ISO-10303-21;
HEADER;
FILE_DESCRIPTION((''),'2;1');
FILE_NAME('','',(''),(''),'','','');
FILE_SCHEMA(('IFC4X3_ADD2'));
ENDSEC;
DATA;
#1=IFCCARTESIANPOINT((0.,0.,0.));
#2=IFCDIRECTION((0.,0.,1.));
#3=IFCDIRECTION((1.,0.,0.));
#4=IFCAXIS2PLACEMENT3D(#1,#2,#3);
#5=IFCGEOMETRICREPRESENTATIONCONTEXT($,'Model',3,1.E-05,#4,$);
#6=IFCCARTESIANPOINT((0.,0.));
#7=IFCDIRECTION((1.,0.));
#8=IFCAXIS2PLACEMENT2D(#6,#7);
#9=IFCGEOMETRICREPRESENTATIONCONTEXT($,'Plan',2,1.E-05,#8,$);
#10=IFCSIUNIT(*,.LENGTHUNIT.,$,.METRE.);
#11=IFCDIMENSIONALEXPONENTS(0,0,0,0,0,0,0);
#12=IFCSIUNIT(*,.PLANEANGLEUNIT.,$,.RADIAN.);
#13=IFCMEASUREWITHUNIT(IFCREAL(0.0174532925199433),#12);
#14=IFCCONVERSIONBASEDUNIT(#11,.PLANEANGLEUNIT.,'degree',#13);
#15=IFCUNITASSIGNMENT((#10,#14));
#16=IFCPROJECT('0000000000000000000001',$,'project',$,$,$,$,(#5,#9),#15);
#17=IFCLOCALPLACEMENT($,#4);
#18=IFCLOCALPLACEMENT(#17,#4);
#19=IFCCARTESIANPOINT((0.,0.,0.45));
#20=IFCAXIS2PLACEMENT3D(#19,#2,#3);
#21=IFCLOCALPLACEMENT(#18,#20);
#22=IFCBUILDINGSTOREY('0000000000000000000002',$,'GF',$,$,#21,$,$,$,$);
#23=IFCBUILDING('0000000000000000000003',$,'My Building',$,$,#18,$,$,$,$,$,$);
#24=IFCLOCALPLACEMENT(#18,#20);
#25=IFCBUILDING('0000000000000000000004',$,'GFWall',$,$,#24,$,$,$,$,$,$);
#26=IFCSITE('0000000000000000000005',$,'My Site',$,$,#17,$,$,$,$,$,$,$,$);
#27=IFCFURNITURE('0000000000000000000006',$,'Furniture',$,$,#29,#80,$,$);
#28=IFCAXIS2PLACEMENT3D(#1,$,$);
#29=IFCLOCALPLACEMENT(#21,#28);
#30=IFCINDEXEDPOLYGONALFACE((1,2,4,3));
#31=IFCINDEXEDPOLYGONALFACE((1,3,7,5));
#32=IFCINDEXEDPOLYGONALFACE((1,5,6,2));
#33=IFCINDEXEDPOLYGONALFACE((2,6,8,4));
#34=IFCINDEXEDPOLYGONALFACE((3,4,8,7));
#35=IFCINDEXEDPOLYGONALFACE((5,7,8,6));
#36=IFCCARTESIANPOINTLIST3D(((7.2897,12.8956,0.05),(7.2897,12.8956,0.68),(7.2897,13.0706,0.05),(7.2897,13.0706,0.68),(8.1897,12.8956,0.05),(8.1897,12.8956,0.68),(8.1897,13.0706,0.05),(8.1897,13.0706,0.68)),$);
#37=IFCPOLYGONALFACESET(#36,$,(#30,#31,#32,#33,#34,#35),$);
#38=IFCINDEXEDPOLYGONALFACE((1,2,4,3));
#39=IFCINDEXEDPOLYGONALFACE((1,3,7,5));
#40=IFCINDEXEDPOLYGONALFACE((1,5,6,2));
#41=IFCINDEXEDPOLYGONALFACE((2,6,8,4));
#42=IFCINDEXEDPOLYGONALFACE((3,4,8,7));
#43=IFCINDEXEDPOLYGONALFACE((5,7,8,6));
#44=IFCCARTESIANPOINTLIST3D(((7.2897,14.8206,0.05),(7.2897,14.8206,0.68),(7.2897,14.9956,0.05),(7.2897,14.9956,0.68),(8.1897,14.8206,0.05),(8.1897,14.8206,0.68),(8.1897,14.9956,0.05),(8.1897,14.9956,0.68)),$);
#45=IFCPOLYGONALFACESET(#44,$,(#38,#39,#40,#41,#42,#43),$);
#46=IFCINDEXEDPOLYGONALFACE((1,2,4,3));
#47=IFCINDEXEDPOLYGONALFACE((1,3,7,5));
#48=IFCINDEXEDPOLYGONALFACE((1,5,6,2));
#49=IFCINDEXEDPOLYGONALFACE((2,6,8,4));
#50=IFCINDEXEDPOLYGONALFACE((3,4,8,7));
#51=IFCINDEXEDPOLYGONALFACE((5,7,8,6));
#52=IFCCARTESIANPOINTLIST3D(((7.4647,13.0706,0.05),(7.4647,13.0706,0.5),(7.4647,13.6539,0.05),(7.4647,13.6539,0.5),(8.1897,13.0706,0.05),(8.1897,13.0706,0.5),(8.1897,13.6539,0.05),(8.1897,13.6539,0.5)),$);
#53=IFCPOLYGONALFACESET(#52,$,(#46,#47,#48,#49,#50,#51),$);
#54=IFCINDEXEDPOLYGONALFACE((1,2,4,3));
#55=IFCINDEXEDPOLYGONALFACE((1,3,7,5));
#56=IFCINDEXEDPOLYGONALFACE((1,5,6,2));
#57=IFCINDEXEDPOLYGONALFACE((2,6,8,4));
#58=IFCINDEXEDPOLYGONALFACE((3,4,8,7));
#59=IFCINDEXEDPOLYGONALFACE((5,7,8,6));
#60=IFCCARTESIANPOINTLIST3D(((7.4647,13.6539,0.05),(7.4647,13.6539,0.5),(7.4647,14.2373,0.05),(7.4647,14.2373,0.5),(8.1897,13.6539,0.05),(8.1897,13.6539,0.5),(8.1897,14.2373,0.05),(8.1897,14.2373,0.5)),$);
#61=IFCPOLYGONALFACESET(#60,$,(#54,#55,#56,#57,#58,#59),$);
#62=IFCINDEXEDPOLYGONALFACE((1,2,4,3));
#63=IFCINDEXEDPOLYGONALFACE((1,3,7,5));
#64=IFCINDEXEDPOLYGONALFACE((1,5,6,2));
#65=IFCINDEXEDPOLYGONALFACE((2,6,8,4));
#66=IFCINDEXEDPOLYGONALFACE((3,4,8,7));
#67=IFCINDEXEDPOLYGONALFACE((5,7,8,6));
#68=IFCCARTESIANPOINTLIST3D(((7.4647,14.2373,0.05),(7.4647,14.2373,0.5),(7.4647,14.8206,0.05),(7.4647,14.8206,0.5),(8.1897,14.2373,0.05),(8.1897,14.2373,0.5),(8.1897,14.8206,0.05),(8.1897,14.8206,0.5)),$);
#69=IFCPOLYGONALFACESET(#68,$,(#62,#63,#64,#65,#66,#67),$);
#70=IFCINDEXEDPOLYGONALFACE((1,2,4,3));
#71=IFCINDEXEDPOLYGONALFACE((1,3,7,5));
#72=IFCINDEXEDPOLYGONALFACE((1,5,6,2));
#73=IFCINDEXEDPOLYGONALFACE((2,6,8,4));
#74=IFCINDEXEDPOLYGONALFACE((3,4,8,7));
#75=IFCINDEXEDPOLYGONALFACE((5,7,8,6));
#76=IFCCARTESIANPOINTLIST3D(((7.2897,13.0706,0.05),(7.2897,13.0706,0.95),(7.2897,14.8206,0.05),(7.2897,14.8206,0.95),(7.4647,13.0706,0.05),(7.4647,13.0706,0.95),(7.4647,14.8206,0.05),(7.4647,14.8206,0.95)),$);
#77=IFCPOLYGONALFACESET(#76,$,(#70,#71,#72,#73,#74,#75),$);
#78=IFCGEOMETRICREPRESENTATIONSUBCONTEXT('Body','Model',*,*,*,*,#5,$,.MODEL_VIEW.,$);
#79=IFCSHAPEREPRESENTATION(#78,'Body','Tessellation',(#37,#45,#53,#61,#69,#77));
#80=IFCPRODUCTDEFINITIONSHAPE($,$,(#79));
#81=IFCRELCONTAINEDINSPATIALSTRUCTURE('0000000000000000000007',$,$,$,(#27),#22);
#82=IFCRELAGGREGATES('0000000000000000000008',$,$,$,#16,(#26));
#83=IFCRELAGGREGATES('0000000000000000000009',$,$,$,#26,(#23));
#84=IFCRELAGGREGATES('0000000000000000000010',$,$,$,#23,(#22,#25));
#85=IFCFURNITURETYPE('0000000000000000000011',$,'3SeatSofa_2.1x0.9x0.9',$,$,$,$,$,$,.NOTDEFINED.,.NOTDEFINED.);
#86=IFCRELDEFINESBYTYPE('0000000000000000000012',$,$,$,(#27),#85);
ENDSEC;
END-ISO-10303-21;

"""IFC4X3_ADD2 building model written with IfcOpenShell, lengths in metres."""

from ifc_helpers import new_model, entity, si_unit, converted_unit, frame, origin_with_axes, origin_2d_with_axis, place, context, subcontext, project, spatial, line, indexed_curve, outline, extrude, shape, source, transform, mapped, type_object, type_shapes, element, save


model = new_model("IFC4X3_ADD2")

# Units and contexts
model_context = context("Model", 3, precision=1e-05, world=origin_with_axes())
plan_context = context("Plan", 2, precision=1e-05, world=origin_2d_with_axis())
body_context_1 = subcontext(model_context, "Body", "Model", "MODEL_VIEW")
body_context_2 = subcontext(plan_context, "Body", "Plan", "PLAN_VIEW")
ifc_project = project(units=[si_unit("LENGTHUNIT", "METRE"), converted_unit("PLANEANGLEUNIT", "degree", entity("IfcReal", 0.0174532925199433), si_unit("PLANEANGLEUNIT", "RADIAN"), dimensions=[0, 0, 0, 0, 0, 0, 0])], contexts=[model_context, plan_context])

# Site, building, storey
site_placement = place(None, origin_with_axes())
site = spatial("IfcSite", under=ifc_project, at=site_placement, Name="My Site")
building_1_placement = place(site_placement, origin_with_axes())
building_1 = spatial("IfcBuilding", under=site, at=building_1_placement, Name="My Building")
storey_placement = place(building_1_placement, frame((0.0, 0.0, 0.45), z_axis=(0.0, 0.0, 1.0), x_axis=(1.0, 0.0, 0.0)))
storey = spatial("IfcBuildingStorey", under=building_1, at=storey_placement, Name="GF")

# Shared definitions
building_2_placement = place(building_1_placement, frame((0.0, 0.0, 0.45), z_axis=(0.0, 0.0, 1.0), x_axis=(1.0, 0.0, 0.0)))
building_2 = spatial("IfcBuilding", under=building_1, at=building_2_placement, Name="GFWall")

# Furniture
furniture_type = type_object("IfcFurnitureType", Name="3SeatSofa_2.1x0.9x0.9", AssemblyPlace="NOTDEFINED", PredefinedType="NOTDEFINED")
shared_shape_1 = source(origin_with_axes(), body_context_1, "Body", "SweptSolid", [
    extrude(outline(indexed_curve([(0.0, 0.0), (0.175, 0.0), (0.175, 0.9), (0.0, 0.9)], segments=[line(1, 2, 3, 4, 1)])), frame((-1.05, -0.9, 0.0), z_axis=(0.0, 0.0, 1.0), x_axis=(1.0, 0.0, 0.0)), (0.0, 0.0, 1.0), 0.63),
    extrude(outline(indexed_curve([(0.0, 0.0), (0.175, 0.0), (0.175, 0.9), (0.0, 0.9)], segments=[line(1, 2, 3, 4, 1)])), frame((0.875, -0.9, 0.0), z_axis=(0.0, 0.0, 1.0), x_axis=(1.0, 0.0, 0.0)), (0.0, 0.0, 1.0), 0.63),
    extrude(outline(indexed_curve([(0.175, 0.0), (0.7583, 0.0), (0.7583, 0.725), (0.175, 0.725)], segments=[line(1, 2, 3, 4, 1)])), frame((-1.05, -0.9, 0.0), z_axis=(0.0, 0.0, 1.0), x_axis=(1.0, 0.0, 0.0)), (0.0, 0.0, 1.0), 0.45),
    extrude(outline(indexed_curve([(0.7583, 0.0), (1.3417, 0.0), (1.3417, 0.725), (0.7583, 0.725)], segments=[line(1, 2, 3, 4, 1)])), frame((-1.05, -0.9, 0.0), z_axis=(0.0, 0.0, 1.0), x_axis=(1.0, 0.0, 0.0)), (0.0, 0.0, 1.0), 0.45),
    extrude(outline(indexed_curve([(1.3417, 0.0), (1.925, 0.0), (1.925, 0.725), (1.3417, 0.725)], segments=[line(1, 2, 3, 4, 1)])), frame((-1.05, -0.9, 0.0), z_axis=(0.0, 0.0, 1.0), x_axis=(1.0, 0.0, 0.0)), (0.0, 0.0, 1.0), 0.45),
    extrude(outline(indexed_curve([(0.175, 0.725), (1.925, 0.725), (1.925, 0.9), (0.175, 0.9)], segments=[line(1, 2, 3, 4, 1)])), frame((-1.05, -0.9, 0.0), z_axis=(0.0, 0.0, 1.0), x_axis=(1.0, 0.0, 0.0)), (0.0, 0.0, 1.0), 0.9),
])
shared_shape_2 = source(origin_with_axes(), body_context_2, "Body", "Curve2D", [
    entity("IfcIndexedPolyCurve", entity("IfcCartesianPointList2D", [[-1.05, -0.9], [-0.875, -0.9], [-0.875, 0.0], [-1.05, 0.0]]), [entity("IfcLineIndex", [1, 2, 3, 4, 1])]),
    entity("IfcIndexedPolyCurve", entity("IfcCartesianPointList2D", [[0.875, -0.9], [1.05, -0.9], [1.05, 0.0], [0.875, 0.0]]), [entity("IfcLineIndex", [1, 2, 3, 4, 1])]),
    entity("IfcIndexedPolyCurve", entity("IfcCartesianPointList2D", [[-0.875, -0.9], [-0.2917, -0.9], [-0.2917, -0.175], [-0.875, -0.175]]), [entity("IfcLineIndex", [1, 2, 3, 4, 1])]),
    entity("IfcIndexedPolyCurve", entity("IfcCartesianPointList2D", [[-0.2917, -0.9], [0.2917, -0.9], [0.2917, -0.175], [-0.2917, -0.175]]), [entity("IfcLineIndex", [1, 2, 3, 4, 1])]),
    entity("IfcIndexedPolyCurve", entity("IfcCartesianPointList2D", [[0.2917, -0.9], [0.875, -0.9], [0.875, -0.175], [0.2917, -0.175]]), [entity("IfcLineIndex", [1, 2, 3, 4, 1])]),
    entity("IfcIndexedPolyCurve", entity("IfcCartesianPointList2D", [[-0.875, -0.175], [0.875, -0.175], [0.875, 0.0], [-0.875, 0.0]]), [entity("IfcLineIndex", [1, 2, 3, 4, 1])]),
])
type_shapes(furniture_type, [shared_shape_1, shared_shape_2])
furniture_placement = place(storey_placement, frame((7.2897, 13.9456, 0.05), z_axis=(0.0, 0.0, 1.0), x_axis=(0.0, 1.0, 0.0)))
element("IfcFurniture", 1, at=furniture_placement, inside=storey, type_object=furniture_type, Name="Furniture", shapes=[
    shape(body_context_1, "Body", "MappedRepresentation", [mapped(shared_shape_1, transform((0.0, 0.0, 0.0), x_axis=(1.0, 0.0, 0.0), y_axis=(0.0, 1.0, 0.0), z_axis=(0.0, 0.0, 1.0), scale=1.0))]),
    shape(body_context_2, "Body", "MappedRepresentation", [mapped(shared_shape_2, transform((0.0, 0.0, 0.0), x_axis=(1.0, 0.0, 0.0), y_axis=(0.0, 1.0, 0.0), z_axis=(0.0, 0.0, 1.0), scale=1.0))]),
])

save(model, "model.ifc")
